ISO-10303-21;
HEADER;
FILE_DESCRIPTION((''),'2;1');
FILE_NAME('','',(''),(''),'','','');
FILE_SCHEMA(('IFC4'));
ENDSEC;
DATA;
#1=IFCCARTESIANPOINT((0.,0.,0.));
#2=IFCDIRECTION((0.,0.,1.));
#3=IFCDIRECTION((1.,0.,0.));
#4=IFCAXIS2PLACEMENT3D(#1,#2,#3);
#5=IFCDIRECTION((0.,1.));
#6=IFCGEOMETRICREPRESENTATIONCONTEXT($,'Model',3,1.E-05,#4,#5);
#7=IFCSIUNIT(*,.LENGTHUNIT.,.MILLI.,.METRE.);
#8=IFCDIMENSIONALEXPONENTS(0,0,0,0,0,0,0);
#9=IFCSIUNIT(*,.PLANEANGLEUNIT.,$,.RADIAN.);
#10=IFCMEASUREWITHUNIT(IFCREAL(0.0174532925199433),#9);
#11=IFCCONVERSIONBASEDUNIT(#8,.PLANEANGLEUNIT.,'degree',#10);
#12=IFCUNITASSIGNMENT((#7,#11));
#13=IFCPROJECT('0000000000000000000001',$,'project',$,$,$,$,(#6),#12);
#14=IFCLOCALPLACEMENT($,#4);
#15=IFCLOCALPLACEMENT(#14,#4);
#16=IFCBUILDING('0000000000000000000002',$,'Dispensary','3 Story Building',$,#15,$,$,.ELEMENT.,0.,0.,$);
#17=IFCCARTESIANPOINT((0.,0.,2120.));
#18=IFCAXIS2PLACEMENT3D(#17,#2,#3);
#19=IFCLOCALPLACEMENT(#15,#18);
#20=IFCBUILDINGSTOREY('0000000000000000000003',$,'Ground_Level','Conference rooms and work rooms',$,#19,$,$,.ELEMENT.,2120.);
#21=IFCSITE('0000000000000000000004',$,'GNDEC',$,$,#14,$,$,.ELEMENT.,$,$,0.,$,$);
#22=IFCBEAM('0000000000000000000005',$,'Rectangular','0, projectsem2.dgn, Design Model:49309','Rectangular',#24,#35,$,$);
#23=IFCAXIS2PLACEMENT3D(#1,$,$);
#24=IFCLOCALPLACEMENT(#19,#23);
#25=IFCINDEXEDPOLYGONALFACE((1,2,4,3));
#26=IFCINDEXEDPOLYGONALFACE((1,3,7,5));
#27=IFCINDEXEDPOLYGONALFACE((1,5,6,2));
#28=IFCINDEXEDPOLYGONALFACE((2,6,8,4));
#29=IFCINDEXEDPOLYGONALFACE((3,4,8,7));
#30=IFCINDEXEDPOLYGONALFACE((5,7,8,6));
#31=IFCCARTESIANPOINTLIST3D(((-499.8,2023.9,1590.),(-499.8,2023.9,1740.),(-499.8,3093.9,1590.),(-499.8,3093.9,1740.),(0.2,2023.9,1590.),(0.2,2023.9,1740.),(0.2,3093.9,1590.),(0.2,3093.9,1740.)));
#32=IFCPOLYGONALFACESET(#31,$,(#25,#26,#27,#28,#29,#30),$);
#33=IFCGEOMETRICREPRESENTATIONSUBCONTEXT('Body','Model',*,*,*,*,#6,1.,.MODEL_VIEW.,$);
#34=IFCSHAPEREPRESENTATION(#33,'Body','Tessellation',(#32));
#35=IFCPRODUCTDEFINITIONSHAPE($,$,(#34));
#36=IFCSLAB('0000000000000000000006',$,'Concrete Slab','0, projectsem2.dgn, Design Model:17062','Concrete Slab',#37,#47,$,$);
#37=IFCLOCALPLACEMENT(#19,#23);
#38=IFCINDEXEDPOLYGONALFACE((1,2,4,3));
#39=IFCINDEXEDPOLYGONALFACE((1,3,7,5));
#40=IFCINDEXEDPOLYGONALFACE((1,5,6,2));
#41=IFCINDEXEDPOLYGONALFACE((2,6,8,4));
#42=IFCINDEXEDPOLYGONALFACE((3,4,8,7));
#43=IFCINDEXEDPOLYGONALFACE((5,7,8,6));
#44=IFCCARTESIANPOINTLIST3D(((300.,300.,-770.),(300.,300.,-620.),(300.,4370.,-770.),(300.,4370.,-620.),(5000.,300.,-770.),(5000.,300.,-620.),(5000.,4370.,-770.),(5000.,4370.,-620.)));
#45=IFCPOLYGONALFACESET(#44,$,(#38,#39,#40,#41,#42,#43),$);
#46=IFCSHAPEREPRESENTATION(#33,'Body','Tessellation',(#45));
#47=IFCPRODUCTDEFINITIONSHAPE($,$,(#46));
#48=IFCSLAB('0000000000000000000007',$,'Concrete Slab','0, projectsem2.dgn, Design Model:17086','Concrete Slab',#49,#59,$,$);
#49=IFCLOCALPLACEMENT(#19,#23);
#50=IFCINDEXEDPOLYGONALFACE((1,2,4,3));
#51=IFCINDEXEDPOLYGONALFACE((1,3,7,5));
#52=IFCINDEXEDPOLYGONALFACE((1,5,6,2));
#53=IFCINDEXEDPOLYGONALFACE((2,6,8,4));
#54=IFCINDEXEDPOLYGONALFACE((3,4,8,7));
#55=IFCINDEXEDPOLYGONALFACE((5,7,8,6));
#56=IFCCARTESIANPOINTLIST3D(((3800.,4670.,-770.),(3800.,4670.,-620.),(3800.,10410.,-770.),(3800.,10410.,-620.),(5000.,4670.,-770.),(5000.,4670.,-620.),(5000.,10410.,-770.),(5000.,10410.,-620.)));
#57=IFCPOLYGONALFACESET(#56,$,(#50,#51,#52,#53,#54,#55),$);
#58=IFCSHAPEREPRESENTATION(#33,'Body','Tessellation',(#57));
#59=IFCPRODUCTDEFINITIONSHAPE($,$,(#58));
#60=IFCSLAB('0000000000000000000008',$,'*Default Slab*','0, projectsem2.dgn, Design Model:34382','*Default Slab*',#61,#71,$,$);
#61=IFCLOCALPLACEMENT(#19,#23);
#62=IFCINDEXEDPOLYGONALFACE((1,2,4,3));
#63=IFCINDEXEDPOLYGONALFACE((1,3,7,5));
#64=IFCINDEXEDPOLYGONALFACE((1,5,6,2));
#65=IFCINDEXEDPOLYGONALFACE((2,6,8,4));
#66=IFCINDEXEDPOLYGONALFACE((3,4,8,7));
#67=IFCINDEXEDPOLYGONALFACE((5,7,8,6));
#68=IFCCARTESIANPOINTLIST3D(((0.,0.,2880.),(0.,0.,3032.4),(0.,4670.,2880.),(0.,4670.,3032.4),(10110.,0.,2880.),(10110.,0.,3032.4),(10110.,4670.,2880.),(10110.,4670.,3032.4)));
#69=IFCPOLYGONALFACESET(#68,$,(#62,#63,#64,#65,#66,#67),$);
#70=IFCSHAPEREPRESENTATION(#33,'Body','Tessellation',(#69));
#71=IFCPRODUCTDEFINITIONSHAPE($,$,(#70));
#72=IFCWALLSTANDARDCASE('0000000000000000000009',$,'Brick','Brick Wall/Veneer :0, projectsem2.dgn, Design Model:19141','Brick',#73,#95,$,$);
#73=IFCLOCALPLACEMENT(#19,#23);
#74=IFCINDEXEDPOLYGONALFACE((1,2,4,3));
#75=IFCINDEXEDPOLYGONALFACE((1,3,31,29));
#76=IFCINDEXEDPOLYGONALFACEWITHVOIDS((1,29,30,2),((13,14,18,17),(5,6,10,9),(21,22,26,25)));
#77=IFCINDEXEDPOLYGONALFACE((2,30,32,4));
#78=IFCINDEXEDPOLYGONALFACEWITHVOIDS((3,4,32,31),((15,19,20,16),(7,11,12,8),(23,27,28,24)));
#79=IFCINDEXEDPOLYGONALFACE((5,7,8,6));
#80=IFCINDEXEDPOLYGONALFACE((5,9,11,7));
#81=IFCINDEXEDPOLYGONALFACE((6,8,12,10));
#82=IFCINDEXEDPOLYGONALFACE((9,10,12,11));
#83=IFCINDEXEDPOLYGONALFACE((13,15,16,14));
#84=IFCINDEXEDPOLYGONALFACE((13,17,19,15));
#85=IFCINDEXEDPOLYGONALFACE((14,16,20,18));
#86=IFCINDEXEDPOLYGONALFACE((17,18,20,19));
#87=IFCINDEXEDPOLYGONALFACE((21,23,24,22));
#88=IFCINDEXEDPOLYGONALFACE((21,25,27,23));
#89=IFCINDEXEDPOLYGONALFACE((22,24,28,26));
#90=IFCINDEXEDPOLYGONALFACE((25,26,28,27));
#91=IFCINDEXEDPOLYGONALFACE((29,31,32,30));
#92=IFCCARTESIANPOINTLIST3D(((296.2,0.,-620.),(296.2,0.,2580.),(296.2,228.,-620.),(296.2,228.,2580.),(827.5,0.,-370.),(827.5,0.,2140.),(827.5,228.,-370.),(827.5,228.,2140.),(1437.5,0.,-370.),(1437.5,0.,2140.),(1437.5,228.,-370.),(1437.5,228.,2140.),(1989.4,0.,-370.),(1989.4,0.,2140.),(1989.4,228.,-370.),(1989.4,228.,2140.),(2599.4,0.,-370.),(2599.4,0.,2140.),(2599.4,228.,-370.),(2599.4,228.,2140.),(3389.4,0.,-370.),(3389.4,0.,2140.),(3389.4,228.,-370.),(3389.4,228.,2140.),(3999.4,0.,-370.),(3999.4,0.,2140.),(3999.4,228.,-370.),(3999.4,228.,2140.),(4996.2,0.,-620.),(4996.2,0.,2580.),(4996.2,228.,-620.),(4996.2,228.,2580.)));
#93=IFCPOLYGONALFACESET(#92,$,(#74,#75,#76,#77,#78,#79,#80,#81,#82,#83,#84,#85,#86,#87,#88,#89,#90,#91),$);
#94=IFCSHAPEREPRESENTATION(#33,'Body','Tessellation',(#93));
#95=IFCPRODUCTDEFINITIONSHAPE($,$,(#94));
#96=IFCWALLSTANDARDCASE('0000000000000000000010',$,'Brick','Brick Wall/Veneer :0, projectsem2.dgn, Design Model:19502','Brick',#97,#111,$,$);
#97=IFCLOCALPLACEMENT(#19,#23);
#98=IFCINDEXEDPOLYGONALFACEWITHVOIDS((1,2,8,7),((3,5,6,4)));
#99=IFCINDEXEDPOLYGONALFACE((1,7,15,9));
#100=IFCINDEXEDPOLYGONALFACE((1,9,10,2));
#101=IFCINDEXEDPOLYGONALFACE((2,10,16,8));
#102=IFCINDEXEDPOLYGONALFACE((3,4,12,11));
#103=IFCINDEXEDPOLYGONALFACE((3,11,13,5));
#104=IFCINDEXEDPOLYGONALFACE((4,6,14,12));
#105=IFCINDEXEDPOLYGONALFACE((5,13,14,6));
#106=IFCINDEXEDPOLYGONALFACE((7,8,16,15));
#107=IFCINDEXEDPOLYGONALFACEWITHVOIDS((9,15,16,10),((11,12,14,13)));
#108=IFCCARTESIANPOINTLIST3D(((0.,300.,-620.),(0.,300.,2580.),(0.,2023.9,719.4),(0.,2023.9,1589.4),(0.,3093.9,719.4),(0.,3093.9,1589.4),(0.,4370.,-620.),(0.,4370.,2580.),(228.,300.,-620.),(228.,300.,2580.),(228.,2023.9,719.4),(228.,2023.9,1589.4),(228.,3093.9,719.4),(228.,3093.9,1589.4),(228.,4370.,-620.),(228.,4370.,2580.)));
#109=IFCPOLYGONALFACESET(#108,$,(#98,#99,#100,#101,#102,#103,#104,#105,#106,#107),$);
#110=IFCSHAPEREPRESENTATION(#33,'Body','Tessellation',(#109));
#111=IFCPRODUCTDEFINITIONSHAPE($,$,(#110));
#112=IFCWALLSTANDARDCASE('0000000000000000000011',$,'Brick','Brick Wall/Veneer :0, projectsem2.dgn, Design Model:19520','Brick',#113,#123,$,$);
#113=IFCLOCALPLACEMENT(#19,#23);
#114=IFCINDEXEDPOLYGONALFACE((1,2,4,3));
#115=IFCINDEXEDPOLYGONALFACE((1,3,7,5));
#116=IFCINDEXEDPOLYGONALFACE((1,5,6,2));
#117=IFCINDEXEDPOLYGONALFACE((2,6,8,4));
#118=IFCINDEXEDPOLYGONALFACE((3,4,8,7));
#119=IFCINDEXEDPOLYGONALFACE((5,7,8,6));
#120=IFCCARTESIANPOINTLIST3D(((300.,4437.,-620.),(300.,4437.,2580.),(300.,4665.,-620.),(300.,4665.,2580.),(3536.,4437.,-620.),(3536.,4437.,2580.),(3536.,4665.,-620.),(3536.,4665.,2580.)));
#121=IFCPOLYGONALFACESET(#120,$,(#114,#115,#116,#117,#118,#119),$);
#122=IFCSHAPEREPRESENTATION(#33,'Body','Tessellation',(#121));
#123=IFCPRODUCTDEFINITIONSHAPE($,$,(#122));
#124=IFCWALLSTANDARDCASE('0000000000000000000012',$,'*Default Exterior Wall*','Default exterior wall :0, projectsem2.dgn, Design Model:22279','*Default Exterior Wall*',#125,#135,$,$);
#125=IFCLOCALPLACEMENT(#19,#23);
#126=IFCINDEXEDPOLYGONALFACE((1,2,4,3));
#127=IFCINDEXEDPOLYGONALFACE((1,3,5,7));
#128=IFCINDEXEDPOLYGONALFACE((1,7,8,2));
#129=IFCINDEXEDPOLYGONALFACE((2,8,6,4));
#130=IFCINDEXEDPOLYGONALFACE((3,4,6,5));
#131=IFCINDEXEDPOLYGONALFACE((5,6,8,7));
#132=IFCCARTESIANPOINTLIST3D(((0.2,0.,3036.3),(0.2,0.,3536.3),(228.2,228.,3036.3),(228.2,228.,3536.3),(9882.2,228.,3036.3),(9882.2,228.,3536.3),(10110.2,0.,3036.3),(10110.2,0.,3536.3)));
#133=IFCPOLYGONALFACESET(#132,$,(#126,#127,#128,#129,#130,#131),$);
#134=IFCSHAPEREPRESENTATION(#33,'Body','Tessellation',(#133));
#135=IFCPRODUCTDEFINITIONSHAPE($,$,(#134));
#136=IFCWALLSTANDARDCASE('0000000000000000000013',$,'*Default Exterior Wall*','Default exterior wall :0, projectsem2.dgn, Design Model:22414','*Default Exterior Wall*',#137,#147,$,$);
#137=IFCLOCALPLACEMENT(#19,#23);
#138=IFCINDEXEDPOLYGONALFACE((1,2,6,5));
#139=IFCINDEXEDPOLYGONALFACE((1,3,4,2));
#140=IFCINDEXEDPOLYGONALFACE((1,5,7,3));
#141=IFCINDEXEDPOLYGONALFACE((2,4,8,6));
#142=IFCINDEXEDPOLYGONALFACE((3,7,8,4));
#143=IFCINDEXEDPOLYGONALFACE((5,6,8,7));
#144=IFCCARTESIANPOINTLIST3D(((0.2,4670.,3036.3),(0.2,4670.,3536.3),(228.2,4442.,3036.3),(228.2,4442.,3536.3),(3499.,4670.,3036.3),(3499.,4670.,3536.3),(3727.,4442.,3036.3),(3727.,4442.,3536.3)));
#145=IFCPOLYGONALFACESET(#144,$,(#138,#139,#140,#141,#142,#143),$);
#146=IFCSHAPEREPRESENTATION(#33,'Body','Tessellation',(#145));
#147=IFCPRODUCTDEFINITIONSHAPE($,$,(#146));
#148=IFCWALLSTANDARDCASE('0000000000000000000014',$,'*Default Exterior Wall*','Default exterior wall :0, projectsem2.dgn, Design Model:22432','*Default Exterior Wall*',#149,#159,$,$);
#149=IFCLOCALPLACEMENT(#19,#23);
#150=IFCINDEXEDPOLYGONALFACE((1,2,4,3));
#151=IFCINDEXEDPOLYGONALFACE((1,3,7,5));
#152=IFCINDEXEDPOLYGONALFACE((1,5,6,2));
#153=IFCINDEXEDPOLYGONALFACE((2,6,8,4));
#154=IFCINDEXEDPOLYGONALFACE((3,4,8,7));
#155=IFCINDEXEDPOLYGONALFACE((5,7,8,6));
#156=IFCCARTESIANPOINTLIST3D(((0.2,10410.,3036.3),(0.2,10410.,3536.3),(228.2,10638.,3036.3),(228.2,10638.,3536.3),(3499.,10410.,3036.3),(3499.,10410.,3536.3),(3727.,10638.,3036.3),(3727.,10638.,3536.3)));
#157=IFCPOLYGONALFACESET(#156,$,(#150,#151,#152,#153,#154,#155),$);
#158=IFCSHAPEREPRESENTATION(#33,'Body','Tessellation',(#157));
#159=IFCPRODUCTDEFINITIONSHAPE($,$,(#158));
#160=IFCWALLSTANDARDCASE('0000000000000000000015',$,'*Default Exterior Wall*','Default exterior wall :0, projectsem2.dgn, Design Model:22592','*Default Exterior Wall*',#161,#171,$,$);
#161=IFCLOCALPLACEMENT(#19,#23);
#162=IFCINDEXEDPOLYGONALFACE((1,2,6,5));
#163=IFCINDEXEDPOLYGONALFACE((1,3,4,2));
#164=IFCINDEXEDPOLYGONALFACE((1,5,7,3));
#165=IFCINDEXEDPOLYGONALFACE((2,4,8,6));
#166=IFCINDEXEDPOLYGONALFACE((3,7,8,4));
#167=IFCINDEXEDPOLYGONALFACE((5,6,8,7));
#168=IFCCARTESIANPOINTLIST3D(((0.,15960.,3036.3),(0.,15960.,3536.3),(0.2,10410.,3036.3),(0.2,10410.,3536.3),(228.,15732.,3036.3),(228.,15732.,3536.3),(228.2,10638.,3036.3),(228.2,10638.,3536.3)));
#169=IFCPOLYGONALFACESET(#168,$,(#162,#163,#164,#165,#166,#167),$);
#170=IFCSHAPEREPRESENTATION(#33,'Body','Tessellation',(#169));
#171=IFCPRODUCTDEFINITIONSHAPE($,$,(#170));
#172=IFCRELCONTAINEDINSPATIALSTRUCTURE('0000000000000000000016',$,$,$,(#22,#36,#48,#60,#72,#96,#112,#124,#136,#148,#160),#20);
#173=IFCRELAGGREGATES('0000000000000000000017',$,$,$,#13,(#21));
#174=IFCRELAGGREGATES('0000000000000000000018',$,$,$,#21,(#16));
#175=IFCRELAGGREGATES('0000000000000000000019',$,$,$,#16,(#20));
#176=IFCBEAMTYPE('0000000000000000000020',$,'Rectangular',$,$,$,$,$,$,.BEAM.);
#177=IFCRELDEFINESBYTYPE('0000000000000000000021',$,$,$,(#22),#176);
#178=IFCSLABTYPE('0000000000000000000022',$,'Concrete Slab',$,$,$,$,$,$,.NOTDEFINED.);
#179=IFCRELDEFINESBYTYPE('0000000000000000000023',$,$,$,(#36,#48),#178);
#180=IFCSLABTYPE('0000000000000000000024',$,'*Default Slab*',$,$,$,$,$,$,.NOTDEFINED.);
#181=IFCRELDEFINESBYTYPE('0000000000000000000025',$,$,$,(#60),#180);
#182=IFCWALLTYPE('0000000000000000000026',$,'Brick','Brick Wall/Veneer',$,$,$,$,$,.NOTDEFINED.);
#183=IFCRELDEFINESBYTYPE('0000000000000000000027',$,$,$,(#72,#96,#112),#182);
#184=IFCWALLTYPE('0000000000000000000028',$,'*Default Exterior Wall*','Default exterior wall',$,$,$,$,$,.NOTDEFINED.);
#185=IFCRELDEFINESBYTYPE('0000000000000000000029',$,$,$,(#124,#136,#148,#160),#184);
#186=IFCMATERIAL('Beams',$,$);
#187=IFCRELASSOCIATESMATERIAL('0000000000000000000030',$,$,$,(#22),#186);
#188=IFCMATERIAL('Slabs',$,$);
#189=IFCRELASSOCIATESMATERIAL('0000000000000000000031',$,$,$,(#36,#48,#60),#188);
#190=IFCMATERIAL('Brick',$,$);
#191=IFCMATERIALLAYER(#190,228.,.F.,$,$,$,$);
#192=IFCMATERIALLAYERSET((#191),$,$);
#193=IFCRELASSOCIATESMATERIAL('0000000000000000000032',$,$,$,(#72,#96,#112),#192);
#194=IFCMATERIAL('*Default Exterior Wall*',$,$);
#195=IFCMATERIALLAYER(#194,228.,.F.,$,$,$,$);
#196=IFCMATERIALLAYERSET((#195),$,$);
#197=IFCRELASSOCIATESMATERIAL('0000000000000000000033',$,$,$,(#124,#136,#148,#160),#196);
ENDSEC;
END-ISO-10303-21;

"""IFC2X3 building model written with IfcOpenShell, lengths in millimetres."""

from ifc_helpers import new_model, entity, si_unit, converted_unit, direction, frame, frame_2d, origin_with_axes, place, context, subcontext, project, spatial, polyline, rectangle, outline, extrude, material, layer, layer_set, layer_usage, type_object, element, save


model = new_model("IFC2X3")

# Units and contexts
model_context = context("Model", 3, precision=1e-05, world=origin_with_axes(), true_north=direction((0.0, 1.0)))
body_context = subcontext(model_context, "Body", "Model", "MODEL_VIEW", scale=1.0)
ifc_project = project(units=[si_unit("LENGTHUNIT", "METRE", prefix="MILLI"), converted_unit("PLANEANGLEUNIT", "degree", entity("IfcReal", 0.0174532925199433), si_unit("PLANEANGLEUNIT", "RADIAN"), dimensions=[0, 0, 0, 0, 0, 0, 0])], contexts=[model_context])

# Site, building, storey
site_placement = place(None, origin_with_axes())
site = spatial("IfcSite", under=ifc_project, at=site_placement, Name="GNDEC", CompositionType="ELEMENT", RefElevation=0.0)
building_placement = place(site_placement, origin_with_axes())
building = spatial("IfcBuilding", under=site, at=building_placement, Name="Dispensary", Description="3 Story Building", CompositionType="ELEMENT", ElevationOfRefHeight=0.0, ElevationOfTerrain=0.0)
storey_placement = place(building_placement, frame((0.0, 0.0, 2120.0), z_axis=(0.0, 0.0, 1.0), x_axis=(1.0, 0.0, 0.0)))
storey = spatial("IfcBuildingStorey", under=building, at=storey_placement, Name="Ground_Level", Description="Conference rooms and work rooms", CompositionType="ELEMENT", Elevation=2120.0)

# Beam
ifc_material_1 = material(Name="Beams")
beam_type = type_object("IfcBeamType", Name="Rectangular", PredefinedType="BEAM")
beam_1_placement = place(storey_placement, frame((-499.8, 3093.9, 1590.0), z_axis=(0.0, -1.0, 0.0), x_axis=(1.0, 0.0, 0.0)))
element("IfcBeam", 1, at=beam_1_placement, inside=storey, type_object=beam_type, material=ifc_material_1, Name="Rectangular", Description="0, projectsem2.dgn, Design Model:49309", ObjectType="Rectangular", context=body_context, shape_type="SweptSolid", body=[
    extrude(rectangle(XDim=150.0, YDim=500.0, at=frame_2d((250.0, 75.0), x_axis=(0.0, 1.0))), origin_with_axes(), (0.0, 0.0, 1.0), 1070.0),
])

# Slabs
ifc_material_2 = material(Name="Slabs")
slab_type_1 = type_object("IfcSlabType", Name="Concrete Slab", PredefinedType="NOTDEFINED")
for number, where, z_axis, x_axis, name in (
    (2, (300.0, 300.0, -620.0), (0.0, 0.0, -1.0), (0.0, 1.0, 0.0), "Concrete Slab"),
):
    element("IfcSlab", number, at=place(storey_placement, frame(where, z_axis=z_axis, x_axis=x_axis)), inside=storey, type_object=slab_type_1, material=ifc_material_2, Name=name, Description="0, projectsem2.dgn, Design Model:17062", ObjectType="Concrete Slab", context=body_context, shape_type="SweptSolid", body=[
        extrude(rectangle(XDim=4070.0, YDim=4700.0, at=frame_2d((2035.0, 2350.0), x_axis=(1.0, 0.0))), origin_with_axes(), (0.0, 0.0, 1.0), 150.0),
    ])
slab_1_placement = place(storey_placement, frame((3800.0, 10410.0, -620.0), z_axis=(0.0, 0.0, -1.0), x_axis=(1.0, 0.0, 0.0)))
element("IfcSlab", 3, at=slab_1_placement, inside=storey, type_object=slab_type_1, material=ifc_material_2, Name="Concrete Slab", Description="0, projectsem2.dgn, Design Model:17086", ObjectType="Concrete Slab", context=body_context, shape_type="SweptSolid", body=[
    extrude(rectangle(XDim=1200.0, YDim=5740.0, at=frame_2d((600.0, 2870.0), x_axis=(1.0, 0.0))), origin_with_axes(), (0.0, 0.0, 1.0), 150.0),
])
slab_type_2 = type_object("IfcSlabType", Name="*Default Slab*", PredefinedType="NOTDEFINED")
slab_2_placement = place(storey_placement, frame((0.0, 4670.0, 2880.0), z_axis=(0.0, 0.0, 1.0), x_axis=(0.0, -1.0, 0.0)))
element("IfcSlab", 4, at=slab_2_placement, inside=storey, type_object=slab_type_2, material=ifc_material_2, Name="*Default Slab*", Description="0, projectsem2.dgn, Design Model:34382", ObjectType="*Default Slab*", context=body_context, shape_type="SweptSolid", body=[
    extrude(rectangle(XDim=4670.0, YDim=10110.0, at=frame_2d((2335.0, 5055.0), x_axis=(1.0, 0.0))), origin_with_axes(), (0.0, 0.0, 1.0), 152.4),
])

# Wall, openings
ifc_material_3 = material(Name="Brick")
ifc_layer_1 = layer(ifc_material_3, 228.0, ventilated=False)
ifc_layer_set_1 = layer_set([ifc_layer_1])
ifc_layer_usage_1 = layer_usage(ifc_layer_set_1, "AXIS2", "POSITIVE", 0.0)
wall_type_1 = type_object("IfcWallType", Name="Brick", Description="Brick Wall/Veneer", PredefinedType="NOTDEFINED")
wall_1_placement = place(storey_placement, frame((4996.2, 228.0, -620.0), z_axis=(0.0, 0.0, 1.0), x_axis=(-1.0, 0.0, 0.0)))
wall_1 = element("IfcWallStandardCase", 5, at=wall_1_placement, inside=storey, type_object=wall_type_1, material=ifc_layer_usage_1, Name="Brick", Description="Brick Wall/Veneer :0, projectsem2.dgn, Design Model:19141", ObjectType="Brick", context=body_context, shape_type="SweptSolid", body=[
    extrude(rectangle(XDim=4700.0, YDim=228.0, at=frame_2d((2350.0, 114.0), x_axis=(-1.0, 0.0))), origin_with_axes(), (0.0, 0.0, 1.0), 3200.0),
])
opening_1_placement = place(wall_1_placement, frame((3558.7, 0.0, 250.0), z_axis=(0.0, 0.0, 1.0), x_axis=(1.0, 0.0, 0.0)))
element("IfcOpeningElement", 6, at=opening_1_placement, cuts=wall_1, ObjectType="Opening", context=body_context, shape_type="SweptSolid", body=[
    extrude(rectangle(XDim=2510.0, YDim=610.0, at=frame_2d((-305.0, 1255.0), x_axis=(0.0, -1.0))), frame((0.0, 0.0, 0.0), z_axis=(0.0, 1.0, 0.0), x_axis=(-1.0, 0.0, 0.0)), (0.0, 0.0, 1.0), 228.0),
])
opening_2_placement = place(wall_1_placement, frame((2396.8, 0.0, 250.0), z_axis=(0.0, 0.0, 1.0), x_axis=(1.0, 0.0, 0.0)))
element("IfcOpeningElement", 7, at=opening_2_placement, cuts=wall_1, ObjectType="Opening", context=body_context, shape_type="SweptSolid", body=[
    extrude(rectangle(XDim=2510.0, YDim=610.0, at=frame_2d((-305.0, 1255.0), x_axis=(0.0, -1.0))), frame((0.0, 0.0, 0.0), z_axis=(0.0, 1.0, 0.0), x_axis=(-1.0, 0.0, 0.0)), (0.0, 0.0, 1.0), 228.0),
])
opening_3_placement = place(wall_1_placement, frame((996.8, 0.0, 250.0), z_axis=(0.0, 0.0, 1.0), x_axis=(1.0, 0.0, 0.0)))
element("IfcOpeningElement", 8, at=opening_3_placement, cuts=wall_1, ObjectType="Opening", context=body_context, shape_type="SweptSolid", body=[
    extrude(rectangle(XDim=2510.0, YDim=610.0, at=frame_2d((-305.0, 1255.0), x_axis=(0.0, -1.0))), frame((0.0, 0.0, 0.0), z_axis=(0.0, 1.0, 0.0), x_axis=(-1.0, 0.0, 0.0)), (0.0, 0.0, 1.0), 228.0),
])

# Wall, opening
wall_2_placement = place(storey_placement, frame((228.0, 4370.0, -620.0), z_axis=(0.0, 0.0, 1.0), x_axis=(0.0, -1.0, 0.0)))
wall_2 = element("IfcWallStandardCase", 9, at=wall_2_placement, inside=storey, type_object=wall_type_1, material=ifc_layer_usage_1, Name="Brick", Description="Brick Wall/Veneer :0, projectsem2.dgn, Design Model:19502", ObjectType="Brick", context=body_context, shape_type="SweptSolid", body=[
    extrude(rectangle(XDim=4070.0, YDim=228.0, at=frame_2d((2035.0, -114.0), x_axis=(1.0, 0.0))), origin_with_axes(), (0.0, 0.0, 1.0), 3200.0),
])
opening_4_placement = place(wall_2_placement, frame((1276.1, -228.0, 1339.4), z_axis=(0.0, 0.0, 1.0), x_axis=(1.0, 0.0, 0.0)))
element("IfcOpeningElement", 10, at=opening_4_placement, cuts=wall_2, ObjectType="Opening", context=body_context, shape_type="SweptSolid", body=[
    extrude(rectangle(XDim=870.0, YDim=1070.0, at=frame_2d((-535.0, 435.0), x_axis=(0.0, -1.0))), frame((0.0, 0.0, 0.0), z_axis=(0.0, 1.0, 0.0), x_axis=(-1.0, 0.0, 0.0)), (0.0, 0.0, 1.0), 228.0),
])

# Walls
wall_3_placement = place(storey_placement, frame((300.0, 4665.0, -620.0), z_axis=(0.0, 0.0, 1.0), x_axis=(1.0, 0.0, 0.0)))
element("IfcWallStandardCase", 11, at=wall_3_placement, inside=storey, type_object=wall_type_1, material=ifc_layer_usage_1, Name="Brick", Description="Brick Wall/Veneer :0, projectsem2.dgn, Design Model:19520", ObjectType="Brick", context=body_context, shape_type="SweptSolid", body=[
    extrude(rectangle(XDim=228.0, YDim=3236.0, at=frame_2d((1618.0, -114.0), x_axis=(0.0, -1.0))), origin_with_axes(), (0.0, 0.0, 1.0), 3200.0),
])
ifc_material_4 = material(Name="*Default Exterior Wall*")
ifc_layer_2 = layer(ifc_material_4, 228.0, ventilated=False)
ifc_layer_set_2 = layer_set([ifc_layer_2])
ifc_layer_usage_2 = layer_usage(ifc_layer_set_2, "AXIS2", "POSITIVE", 0.0)
wall_type_2 = type_object("IfcWallType", Name="*Default Exterior Wall*", Description="Default exterior wall", PredefinedType="NOTDEFINED")
wall_4_placement = place(storey_placement, frame((228.2, 228.0, 3036.3), z_axis=(0.0, 0.0, 1.0), x_axis=(1.0, 0.0, 0.0)))
element("IfcWallStandardCase", 12, at=wall_4_placement, inside=storey, type_object=wall_type_2, material=ifc_layer_usage_2, Name="*Default Exterior Wall*", Description="Default exterior wall :0, projectsem2.dgn, Design Model:22279", ObjectType="*Default Exterior Wall*", context=body_context, shape_type="SweptSolid", body=[
    extrude(outline(polyline([(9654.0, 0.0), (0.0, 0.0), (-228.0, -228.0), (9882.0, -228.0), (9654.0, 0.0)])), origin_with_axes(), (0.0, 0.0, 1.0), 500.0),
])
wall_5_placement = place(storey_placement, frame((0.2, 4670.0, 3036.3), z_axis=(0.0, 0.0, 1.0), x_axis=(1.0, 0.0, 0.0)))
element("IfcWallStandardCase", 13, at=wall_5_placement, inside=storey, type_object=wall_type_2, material=ifc_layer_usage_2, Name="*Default Exterior Wall*", Description="Default exterior wall :0, projectsem2.dgn, Design Model:22414", ObjectType="*Default Exterior Wall*", context=body_context, shape_type="SweptSolid", body=[
    extrude(outline(polyline([(3498.8, 0.0), (0.0, 0.0), (228.0, -228.0), (3726.8, -228.0), (3498.8, 0.0)])), origin_with_axes(), (0.0, 0.0, 1.0), 500.0),
])
wall_6_placement = place(storey_placement, frame((3499.0, 10410.0, 3036.3), z_axis=(0.0, 0.0, 1.0), x_axis=(-1.0, 0.0, 0.0)))
element("IfcWallStandardCase", 14, at=wall_6_placement, inside=storey, type_object=wall_type_2, material=ifc_layer_usage_2, Name="*Default Exterior Wall*", Description="Default exterior wall :0, projectsem2.dgn, Design Model:22432", ObjectType="*Default Exterior Wall*", context=body_context, shape_type="SweptSolid", body=[
    extrude(outline(polyline([(3498.8, 0.0), (0.0, 0.0), (-228.0, -228.0), (3270.8, -228.0), (3498.8, 0.0)])), origin_with_axes(), (0.0, 0.0, 1.0), 500.0),
])
wall_7_placement = place(storey_placement, frame((0.2, 10410.0, 3036.3), z_axis=(0.0, 0.0, 1.0), x_axis=(-0.000031, 1.0, 0.0)))
element("IfcWallStandardCase", 15, at=wall_7_placement, inside=storey, type_object=wall_type_2, material=ifc_layer_usage_2, Name="*Default Exterior Wall*", Description="Default exterior wall :0, projectsem2.dgn, Design Model:22592", ObjectType="*Default Exterior Wall*", context=body_context, shape_type="SweptSolid", body=[
    extrude(outline(polyline([(5550.0, 0.0), (0.0, 0.0), (228.0, -228.0), (5322.0, -228.0), (5550.0, 0.0)])), origin_with_axes(), (0.0, 0.0, 1.0), 500.0),
])

save(model, "model.ifc")
